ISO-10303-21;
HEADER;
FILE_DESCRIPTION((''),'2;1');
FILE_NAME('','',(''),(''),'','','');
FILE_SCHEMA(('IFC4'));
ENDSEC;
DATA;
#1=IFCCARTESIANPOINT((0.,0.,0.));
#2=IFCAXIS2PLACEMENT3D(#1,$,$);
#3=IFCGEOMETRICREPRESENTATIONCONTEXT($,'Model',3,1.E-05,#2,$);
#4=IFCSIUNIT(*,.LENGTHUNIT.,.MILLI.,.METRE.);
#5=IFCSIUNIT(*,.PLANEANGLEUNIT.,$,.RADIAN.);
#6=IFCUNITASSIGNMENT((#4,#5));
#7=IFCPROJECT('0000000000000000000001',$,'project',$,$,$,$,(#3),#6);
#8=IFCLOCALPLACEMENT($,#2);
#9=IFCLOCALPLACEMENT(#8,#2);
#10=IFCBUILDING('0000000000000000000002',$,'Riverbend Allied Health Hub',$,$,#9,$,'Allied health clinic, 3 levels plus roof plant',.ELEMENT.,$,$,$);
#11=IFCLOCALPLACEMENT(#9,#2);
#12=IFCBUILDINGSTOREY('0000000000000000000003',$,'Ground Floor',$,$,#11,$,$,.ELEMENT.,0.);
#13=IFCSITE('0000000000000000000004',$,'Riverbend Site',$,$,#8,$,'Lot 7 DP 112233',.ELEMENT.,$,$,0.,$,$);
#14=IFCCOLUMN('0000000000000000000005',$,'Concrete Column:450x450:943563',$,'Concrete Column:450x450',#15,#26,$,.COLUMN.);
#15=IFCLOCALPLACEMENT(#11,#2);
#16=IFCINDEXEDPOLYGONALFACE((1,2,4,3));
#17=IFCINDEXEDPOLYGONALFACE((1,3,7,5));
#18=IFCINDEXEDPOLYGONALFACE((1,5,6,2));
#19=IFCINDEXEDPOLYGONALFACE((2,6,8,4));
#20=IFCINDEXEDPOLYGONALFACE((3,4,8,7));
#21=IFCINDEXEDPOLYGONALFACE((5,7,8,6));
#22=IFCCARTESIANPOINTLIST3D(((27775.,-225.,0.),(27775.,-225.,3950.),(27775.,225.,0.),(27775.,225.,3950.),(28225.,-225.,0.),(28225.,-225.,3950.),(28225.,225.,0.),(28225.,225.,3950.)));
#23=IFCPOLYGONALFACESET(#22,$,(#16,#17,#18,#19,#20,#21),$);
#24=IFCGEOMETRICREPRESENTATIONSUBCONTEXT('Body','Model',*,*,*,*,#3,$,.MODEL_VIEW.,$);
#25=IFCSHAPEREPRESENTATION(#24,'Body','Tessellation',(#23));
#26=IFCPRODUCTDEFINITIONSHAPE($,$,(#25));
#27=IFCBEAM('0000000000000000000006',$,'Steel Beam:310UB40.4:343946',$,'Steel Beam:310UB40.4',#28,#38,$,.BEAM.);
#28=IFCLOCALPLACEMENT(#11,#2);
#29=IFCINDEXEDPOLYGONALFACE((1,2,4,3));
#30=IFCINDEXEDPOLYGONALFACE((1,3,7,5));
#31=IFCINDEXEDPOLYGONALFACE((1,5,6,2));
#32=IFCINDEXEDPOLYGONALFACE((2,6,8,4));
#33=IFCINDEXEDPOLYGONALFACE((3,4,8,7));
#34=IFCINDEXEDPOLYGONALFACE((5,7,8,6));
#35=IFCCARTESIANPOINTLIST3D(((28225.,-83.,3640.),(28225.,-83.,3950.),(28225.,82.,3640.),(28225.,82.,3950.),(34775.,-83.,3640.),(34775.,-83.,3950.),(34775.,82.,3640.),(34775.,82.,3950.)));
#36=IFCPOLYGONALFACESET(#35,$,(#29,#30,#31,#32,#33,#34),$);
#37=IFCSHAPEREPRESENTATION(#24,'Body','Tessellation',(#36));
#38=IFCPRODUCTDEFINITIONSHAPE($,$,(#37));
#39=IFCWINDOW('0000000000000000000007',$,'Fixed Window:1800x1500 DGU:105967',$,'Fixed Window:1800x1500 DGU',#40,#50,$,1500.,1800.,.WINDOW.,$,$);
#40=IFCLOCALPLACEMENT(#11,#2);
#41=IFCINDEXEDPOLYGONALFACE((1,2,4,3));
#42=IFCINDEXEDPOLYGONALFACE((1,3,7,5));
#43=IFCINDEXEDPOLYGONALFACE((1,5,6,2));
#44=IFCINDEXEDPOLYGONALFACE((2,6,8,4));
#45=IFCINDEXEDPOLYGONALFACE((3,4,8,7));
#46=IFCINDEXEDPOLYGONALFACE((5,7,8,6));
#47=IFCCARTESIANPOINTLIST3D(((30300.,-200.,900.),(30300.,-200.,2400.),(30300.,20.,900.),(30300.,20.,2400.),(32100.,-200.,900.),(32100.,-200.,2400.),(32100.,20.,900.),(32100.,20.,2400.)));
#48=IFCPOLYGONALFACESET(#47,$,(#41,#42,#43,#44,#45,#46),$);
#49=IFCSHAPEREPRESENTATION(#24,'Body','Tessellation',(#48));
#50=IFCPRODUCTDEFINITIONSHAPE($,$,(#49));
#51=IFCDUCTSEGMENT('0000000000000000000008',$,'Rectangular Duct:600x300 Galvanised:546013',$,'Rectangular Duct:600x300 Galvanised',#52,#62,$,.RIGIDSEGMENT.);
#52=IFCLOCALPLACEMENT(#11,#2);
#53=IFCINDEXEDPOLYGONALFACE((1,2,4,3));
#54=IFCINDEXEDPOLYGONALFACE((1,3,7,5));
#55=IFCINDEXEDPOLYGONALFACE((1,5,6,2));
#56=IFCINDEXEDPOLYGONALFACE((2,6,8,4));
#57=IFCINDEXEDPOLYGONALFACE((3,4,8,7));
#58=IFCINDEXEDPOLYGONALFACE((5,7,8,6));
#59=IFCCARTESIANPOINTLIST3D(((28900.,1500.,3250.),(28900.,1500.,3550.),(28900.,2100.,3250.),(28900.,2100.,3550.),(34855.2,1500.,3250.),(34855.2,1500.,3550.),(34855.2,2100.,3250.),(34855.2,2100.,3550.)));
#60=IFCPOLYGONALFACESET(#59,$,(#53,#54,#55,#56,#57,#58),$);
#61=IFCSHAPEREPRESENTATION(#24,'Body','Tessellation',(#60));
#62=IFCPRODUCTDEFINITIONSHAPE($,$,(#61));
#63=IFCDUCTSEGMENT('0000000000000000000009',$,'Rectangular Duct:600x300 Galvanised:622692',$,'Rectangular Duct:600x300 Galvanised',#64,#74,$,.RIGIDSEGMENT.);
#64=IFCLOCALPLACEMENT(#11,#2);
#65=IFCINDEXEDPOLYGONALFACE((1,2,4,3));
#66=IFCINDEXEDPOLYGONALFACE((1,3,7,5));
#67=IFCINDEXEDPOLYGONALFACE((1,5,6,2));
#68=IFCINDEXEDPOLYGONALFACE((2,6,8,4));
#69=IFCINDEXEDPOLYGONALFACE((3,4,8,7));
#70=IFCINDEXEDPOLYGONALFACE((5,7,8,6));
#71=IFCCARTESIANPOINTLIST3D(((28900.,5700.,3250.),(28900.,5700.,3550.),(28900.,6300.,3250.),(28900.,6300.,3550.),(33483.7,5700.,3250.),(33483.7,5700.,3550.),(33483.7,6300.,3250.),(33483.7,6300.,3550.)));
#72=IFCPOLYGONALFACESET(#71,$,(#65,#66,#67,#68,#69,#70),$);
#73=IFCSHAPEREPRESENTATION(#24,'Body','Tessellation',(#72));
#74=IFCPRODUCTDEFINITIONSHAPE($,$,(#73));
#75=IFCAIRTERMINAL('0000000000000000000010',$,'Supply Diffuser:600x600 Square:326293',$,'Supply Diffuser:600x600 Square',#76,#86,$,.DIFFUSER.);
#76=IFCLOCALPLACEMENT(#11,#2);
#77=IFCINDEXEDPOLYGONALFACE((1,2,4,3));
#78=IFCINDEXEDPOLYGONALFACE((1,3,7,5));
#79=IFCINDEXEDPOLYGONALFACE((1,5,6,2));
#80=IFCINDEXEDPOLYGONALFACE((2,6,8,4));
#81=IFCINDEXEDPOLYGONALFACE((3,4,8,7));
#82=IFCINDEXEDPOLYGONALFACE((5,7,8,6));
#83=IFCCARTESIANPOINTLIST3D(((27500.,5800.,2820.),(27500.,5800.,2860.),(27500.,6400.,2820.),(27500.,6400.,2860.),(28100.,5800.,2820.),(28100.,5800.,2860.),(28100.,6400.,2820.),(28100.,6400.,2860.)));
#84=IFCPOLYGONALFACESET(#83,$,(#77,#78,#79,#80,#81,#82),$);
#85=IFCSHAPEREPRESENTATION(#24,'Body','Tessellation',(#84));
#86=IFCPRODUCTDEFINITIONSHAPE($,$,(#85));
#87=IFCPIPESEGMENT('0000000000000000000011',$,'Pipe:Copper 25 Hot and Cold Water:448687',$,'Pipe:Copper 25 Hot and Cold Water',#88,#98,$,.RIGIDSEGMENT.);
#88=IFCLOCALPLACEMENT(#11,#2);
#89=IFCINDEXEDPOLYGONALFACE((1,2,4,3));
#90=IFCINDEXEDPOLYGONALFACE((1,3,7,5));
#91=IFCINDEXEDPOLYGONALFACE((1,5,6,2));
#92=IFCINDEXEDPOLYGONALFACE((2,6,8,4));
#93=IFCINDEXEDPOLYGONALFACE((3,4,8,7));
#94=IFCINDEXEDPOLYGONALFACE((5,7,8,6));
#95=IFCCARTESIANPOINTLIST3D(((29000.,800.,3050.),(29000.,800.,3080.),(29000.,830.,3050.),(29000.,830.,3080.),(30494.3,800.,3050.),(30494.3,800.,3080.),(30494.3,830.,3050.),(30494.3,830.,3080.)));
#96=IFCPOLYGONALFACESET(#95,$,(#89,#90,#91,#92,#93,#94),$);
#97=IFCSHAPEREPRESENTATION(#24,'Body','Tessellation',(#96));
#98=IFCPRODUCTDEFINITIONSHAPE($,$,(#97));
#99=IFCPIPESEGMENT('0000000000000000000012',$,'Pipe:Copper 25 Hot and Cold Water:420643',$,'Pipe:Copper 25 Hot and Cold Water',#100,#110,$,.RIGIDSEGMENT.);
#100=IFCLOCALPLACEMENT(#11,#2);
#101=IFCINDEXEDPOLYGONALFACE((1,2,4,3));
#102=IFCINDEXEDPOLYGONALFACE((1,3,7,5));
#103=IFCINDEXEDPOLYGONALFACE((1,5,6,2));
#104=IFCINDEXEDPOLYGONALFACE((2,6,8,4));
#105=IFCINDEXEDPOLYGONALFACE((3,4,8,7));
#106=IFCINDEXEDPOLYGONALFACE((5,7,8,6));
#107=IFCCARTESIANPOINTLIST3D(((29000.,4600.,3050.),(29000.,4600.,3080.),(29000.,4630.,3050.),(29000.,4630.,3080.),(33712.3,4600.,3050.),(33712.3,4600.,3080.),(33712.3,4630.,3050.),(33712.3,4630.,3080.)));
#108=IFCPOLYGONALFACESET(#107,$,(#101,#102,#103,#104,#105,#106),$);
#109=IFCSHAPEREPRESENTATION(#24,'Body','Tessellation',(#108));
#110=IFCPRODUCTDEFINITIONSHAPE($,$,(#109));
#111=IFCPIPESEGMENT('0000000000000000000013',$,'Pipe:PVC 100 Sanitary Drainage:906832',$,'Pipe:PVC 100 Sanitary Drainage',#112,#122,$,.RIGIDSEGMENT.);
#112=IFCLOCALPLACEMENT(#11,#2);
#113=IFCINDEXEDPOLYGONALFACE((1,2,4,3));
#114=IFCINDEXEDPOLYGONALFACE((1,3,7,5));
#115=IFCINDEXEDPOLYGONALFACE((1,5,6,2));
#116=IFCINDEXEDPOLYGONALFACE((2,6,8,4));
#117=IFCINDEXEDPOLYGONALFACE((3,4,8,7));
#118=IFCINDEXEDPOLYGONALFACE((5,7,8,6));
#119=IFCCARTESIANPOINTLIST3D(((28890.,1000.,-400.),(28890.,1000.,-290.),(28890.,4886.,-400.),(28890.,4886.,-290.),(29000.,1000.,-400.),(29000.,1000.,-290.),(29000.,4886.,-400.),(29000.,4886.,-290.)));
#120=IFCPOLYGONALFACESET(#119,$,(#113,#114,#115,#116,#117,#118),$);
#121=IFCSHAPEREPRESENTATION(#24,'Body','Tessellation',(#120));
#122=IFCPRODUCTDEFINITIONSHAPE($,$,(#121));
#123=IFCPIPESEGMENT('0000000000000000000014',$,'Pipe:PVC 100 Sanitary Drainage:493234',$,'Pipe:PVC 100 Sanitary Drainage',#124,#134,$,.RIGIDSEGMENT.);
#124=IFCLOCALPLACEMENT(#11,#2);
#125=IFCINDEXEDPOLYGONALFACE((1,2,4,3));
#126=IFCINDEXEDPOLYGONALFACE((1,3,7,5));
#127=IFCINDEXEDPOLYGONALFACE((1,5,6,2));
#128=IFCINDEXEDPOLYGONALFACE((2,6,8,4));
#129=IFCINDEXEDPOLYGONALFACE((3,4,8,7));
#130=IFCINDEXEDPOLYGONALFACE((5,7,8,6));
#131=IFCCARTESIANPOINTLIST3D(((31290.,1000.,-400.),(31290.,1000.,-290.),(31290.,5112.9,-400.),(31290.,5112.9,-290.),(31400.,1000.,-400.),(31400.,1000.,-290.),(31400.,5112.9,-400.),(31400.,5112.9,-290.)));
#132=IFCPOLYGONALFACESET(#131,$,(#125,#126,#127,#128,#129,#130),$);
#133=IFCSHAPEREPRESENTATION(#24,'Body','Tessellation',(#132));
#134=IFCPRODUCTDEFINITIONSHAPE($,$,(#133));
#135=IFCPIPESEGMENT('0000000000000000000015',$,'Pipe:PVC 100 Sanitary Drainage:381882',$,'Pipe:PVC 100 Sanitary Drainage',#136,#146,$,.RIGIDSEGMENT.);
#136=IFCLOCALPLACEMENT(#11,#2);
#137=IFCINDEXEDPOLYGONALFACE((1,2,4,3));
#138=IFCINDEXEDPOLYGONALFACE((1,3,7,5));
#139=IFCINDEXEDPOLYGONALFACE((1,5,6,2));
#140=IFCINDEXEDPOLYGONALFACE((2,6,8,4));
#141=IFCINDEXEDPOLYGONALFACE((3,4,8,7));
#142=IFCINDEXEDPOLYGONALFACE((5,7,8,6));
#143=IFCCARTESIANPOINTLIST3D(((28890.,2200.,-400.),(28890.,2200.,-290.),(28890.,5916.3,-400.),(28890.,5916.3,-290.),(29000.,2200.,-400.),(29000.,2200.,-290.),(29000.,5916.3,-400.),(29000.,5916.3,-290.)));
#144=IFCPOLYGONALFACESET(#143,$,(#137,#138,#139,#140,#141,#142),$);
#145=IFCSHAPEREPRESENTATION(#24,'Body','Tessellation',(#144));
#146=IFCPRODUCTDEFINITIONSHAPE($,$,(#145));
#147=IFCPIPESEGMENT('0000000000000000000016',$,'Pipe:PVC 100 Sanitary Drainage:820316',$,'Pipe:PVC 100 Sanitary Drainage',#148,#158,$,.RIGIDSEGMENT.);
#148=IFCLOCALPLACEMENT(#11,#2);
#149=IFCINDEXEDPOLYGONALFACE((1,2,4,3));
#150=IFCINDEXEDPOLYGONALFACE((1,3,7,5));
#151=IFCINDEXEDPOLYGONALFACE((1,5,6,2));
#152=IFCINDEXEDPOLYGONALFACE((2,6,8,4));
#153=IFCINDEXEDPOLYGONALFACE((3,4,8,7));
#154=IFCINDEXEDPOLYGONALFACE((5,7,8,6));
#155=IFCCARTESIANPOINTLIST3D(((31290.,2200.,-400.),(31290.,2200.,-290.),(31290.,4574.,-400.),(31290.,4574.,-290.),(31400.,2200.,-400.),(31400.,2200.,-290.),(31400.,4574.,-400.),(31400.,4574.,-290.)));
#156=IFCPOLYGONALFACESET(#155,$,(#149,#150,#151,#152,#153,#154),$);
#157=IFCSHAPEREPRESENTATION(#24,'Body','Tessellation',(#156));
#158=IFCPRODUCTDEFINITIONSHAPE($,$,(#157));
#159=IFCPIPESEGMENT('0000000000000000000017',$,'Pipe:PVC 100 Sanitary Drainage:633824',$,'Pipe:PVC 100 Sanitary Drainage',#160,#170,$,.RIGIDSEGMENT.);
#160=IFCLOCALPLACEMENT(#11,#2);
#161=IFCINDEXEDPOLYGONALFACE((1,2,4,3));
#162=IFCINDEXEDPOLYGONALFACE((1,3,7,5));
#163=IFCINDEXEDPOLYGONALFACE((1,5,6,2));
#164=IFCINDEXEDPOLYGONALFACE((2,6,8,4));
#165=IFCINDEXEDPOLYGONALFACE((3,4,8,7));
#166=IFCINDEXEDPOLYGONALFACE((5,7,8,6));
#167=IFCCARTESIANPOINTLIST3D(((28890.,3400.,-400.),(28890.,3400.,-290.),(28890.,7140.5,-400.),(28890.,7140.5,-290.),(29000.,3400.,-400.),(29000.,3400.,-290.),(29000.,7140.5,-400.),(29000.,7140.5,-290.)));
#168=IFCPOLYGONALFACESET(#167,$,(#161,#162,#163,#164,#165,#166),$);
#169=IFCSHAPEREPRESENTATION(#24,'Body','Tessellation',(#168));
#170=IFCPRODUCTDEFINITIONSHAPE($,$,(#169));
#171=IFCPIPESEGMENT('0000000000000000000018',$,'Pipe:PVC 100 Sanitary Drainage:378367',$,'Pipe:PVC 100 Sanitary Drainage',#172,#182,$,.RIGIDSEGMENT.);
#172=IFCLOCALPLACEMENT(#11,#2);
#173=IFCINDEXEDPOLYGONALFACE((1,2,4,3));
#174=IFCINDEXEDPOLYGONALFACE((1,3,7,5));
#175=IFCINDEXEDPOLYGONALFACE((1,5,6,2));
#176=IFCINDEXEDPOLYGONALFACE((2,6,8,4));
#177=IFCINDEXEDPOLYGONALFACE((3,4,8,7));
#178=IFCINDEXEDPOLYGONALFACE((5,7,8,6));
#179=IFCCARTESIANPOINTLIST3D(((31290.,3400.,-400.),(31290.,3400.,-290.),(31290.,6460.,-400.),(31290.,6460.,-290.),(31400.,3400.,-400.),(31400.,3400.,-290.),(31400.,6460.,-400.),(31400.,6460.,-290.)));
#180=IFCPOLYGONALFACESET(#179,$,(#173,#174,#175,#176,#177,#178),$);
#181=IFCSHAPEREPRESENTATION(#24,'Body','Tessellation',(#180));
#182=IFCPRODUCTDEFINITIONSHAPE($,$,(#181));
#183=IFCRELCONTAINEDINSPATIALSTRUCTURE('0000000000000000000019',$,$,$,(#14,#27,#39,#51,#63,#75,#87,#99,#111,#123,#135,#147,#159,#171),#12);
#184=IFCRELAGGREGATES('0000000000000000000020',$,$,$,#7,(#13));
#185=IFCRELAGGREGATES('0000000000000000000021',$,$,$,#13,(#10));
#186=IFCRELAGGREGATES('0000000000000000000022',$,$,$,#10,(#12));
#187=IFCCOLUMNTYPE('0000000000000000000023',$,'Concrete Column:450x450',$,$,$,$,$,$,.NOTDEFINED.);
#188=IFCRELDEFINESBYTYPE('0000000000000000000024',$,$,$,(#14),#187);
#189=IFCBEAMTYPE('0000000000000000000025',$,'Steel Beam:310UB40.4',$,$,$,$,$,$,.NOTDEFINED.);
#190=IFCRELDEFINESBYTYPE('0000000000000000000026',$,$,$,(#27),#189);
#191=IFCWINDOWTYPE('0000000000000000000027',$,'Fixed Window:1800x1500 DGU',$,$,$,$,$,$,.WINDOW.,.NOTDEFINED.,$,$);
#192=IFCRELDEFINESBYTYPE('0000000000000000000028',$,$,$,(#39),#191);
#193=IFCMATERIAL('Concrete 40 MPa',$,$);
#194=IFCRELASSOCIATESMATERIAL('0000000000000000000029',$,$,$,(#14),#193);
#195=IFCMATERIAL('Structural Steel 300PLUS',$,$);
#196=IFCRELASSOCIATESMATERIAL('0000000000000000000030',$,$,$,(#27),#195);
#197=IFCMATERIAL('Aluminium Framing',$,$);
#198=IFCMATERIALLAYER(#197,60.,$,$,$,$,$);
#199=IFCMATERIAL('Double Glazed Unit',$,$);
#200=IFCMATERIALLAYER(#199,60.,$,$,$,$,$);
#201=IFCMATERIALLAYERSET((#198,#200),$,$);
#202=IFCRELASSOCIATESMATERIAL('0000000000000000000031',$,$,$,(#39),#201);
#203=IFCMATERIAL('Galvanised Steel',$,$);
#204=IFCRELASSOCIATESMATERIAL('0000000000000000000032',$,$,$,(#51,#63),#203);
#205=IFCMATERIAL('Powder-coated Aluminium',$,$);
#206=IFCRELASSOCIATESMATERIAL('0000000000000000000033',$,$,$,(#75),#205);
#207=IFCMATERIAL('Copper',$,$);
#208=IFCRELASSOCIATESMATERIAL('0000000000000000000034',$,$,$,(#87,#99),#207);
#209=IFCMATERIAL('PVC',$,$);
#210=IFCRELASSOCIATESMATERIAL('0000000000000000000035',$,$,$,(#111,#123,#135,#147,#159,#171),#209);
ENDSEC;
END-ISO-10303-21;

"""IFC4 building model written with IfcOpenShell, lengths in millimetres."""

from ifc_helpers import new_model, si_unit, frame, frame_2d, origin, place, context, subcontext, project, spatial, rectangle, extrude, material, layer, layer_set, layer_usage, type_object, element, save


model = new_model("IFC4")

# Units and contexts
model_context = context("Model", 3, precision=1e-05, world=origin())
body_context = subcontext(model_context, "Body", "Model", "MODEL_VIEW")
ifc_project = project(units=[si_unit("LENGTHUNIT", "METRE", prefix="MILLI"), si_unit("PLANEANGLEUNIT", "RADIAN")], contexts=[model_context])

# Site, building, storey
site_placement = place(None, origin())
site = spatial("IfcSite", under=ifc_project, at=site_placement, Name="Riverbend Site", LongName="Lot 7 DP 112233", CompositionType="ELEMENT", RefElevation=0.0)
building_placement = place(site_placement, origin())
building = spatial("IfcBuilding", under=site, at=building_placement, Name="Riverbend Allied Health Hub", LongName="Allied health clinic, 3 levels plus roof plant", CompositionType="ELEMENT")
storey_placement = place(building_placement, origin())
storey = spatial("IfcBuildingStorey", under=building, at=storey_placement, Name="Ground Floor", CompositionType="ELEMENT", Elevation=0.0)

# Column
ifc_material_1 = material(Name="Concrete 40 MPa")
column_type = type_object("IfcColumnType", Name="Concrete Column:450x450", PredefinedType="NOTDEFINED")
column_placement = place(storey_placement, frame((27775.0, -225.0, 0.0)))
element("IfcColumn", 1, at=column_placement, inside=storey, type_object=column_type, material=ifc_material_1, Name="Concrete Column:450x450:943563", ObjectType="Concrete Column:450x450", PredefinedType="COLUMN", context=body_context, shape_type="SweptSolid", body=[
    extrude(rectangle(XDim=450.0, YDim=450.0, at=frame_2d((225.0, 225.0))), origin(), (0.0, 0.0, 1.0), 3950.0),
])

# Beam
ifc_material_2 = material(Name="Structural Steel 300PLUS")
beam_type = type_object("IfcBeamType", Name="Steel Beam:310UB40.4", PredefinedType="NOTDEFINED")
beam_placement = place(storey_placement, frame((28225.0, -83.0, 3640.0)))
element("IfcBeam", 2, at=beam_placement, inside=storey, type_object=beam_type, material=ifc_material_2, Name="Steel Beam:310UB40.4:343946", ObjectType="Steel Beam:310UB40.4", PredefinedType="BEAM", context=body_context, shape_type="SweptSolid", body=[
    extrude(rectangle(XDim=6550.0, YDim=165.0, at=frame_2d((3275.0, 82.5))), origin(), (0.0, 0.0, 1.0), 310.0),
])

# Window
ifc_material_3 = material(Name="Aluminium Framing")
ifc_layer_1 = layer(ifc_material_3, 60.0)
ifc_material_4 = material(Name="Double Glazed Unit")
ifc_layer_2 = layer(ifc_material_4, 60.0)
ifc_layer_set = layer_set([ifc_layer_1, ifc_layer_2])
ifc_layer_usage = layer_usage(ifc_layer_set, "AXIS2", "POSITIVE", 0.0)
window_type = type_object("IfcWindowType", Name="Fixed Window:1800x1500 DGU", PartitioningType="NOTDEFINED", PredefinedType="WINDOW")
window_placement = place(storey_placement, frame((30300.0, -200.0, 900.0)))
element("IfcWindow", 3, at=window_placement, inside=storey, type_object=window_type, material=ifc_layer_usage, Name="Fixed Window:1800x1500 DGU:105967", ObjectType="Fixed Window:1800x1500 DGU", OverallHeight=1500.0, OverallWidth=1800.0, PredefinedType="WINDOW", context=body_context, shape_type="SweptSolid", body=[
    extrude(rectangle(XDim=1800.0, YDim=220.0, at=frame_2d((900.0, 110.0))), origin(), (0.0, 0.0, 1.0), 1500.0),
])

# Duct segments
ifc_material_5 = material(Name="Galvanised Steel")
duct_segment_1_placement = place(storey_placement, frame((28900.0, 1500.0, 3250.0)))
element("IfcDuctSegment", 4, at=duct_segment_1_placement, inside=storey, material=ifc_material_5, Name="Rectangular Duct:600x300 Galvanised:546013", ObjectType="Rectangular Duct:600x300 Galvanised", PredefinedType="RIGIDSEGMENT", context=body_context, shape_type="SweptSolid", body=[
    extrude(rectangle(XDim=5955.2, YDim=600.0, at=frame_2d((2977.6, 300.0))), origin(), (0.0, 0.0, 1.0), 300.0),
])
duct_segment_2_placement = place(storey_placement, frame((28900.0, 5700.0, 3250.0)))
element("IfcDuctSegment", 5, at=duct_segment_2_placement, inside=storey, material=ifc_material_5, Name="Rectangular Duct:600x300 Galvanised:622692", ObjectType="Rectangular Duct:600x300 Galvanised", PredefinedType="RIGIDSEGMENT", context=body_context, shape_type="SweptSolid", body=[
    extrude(rectangle(XDim=4583.7, YDim=600.0, at=frame_2d((2291.8, 300.0))), origin(), (0.0, 0.0, 1.0), 300.0),
])

# Air terminal
ifc_material_6 = material(Name="Powder-coated Aluminium")
air_terminal_placement = place(storey_placement, frame((27500.0, 5800.0, 2820.0)))
element("IfcAirTerminal", 6, at=air_terminal_placement, inside=storey, material=ifc_material_6, Name="Supply Diffuser:600x600 Square:326293", ObjectType="Supply Diffuser:600x600 Square", PredefinedType="DIFFUSER", context=body_context, shape_type="SweptSolid", body=[
    extrude(rectangle(XDim=600.0, YDim=600.0, at=frame_2d((300.0, 300.0))), origin(), (0.0, 0.0, 1.0), 40.0),
])

# Pipe segments
ifc_material_7 = material(Name="Copper")
pipe_segment_1_placement = place(storey_placement, frame((29000.0, 800.0, 3050.0)))
element("IfcPipeSegment", 7, at=pipe_segment_1_placement, inside=storey, material=ifc_material_7, Name="Pipe:Copper 25 Hot and Cold Water:448687", ObjectType="Pipe:Copper 25 Hot and Cold Water", PredefinedType="RIGIDSEGMENT", context=body_context, shape_type="SweptSolid", body=[
    extrude(rectangle(XDim=1494.3, YDim=30.0, at=frame_2d((747.1, 15.0))), origin(), (0.0, 0.0, 1.0), 30.0),
])
pipe_segment_2_placement = place(storey_placement, frame((29000.0, 4600.0, 3050.0)))
element("IfcPipeSegment", 8, at=pipe_segment_2_placement, inside=storey, material=ifc_material_7, Name="Pipe:Copper 25 Hot and Cold Water:420643", ObjectType="Pipe:Copper 25 Hot and Cold Water", PredefinedType="RIGIDSEGMENT", context=body_context, shape_type="SweptSolid", body=[
    extrude(rectangle(XDim=4712.3, YDim=30.0, at=frame_2d((2356.1, 15.0))), origin(), (0.0, 0.0, 1.0), 30.0),
])
ifc_material_8 = material(Name="PVC")
pipe_segment_3_placement = place(storey_placement, frame((29000.0, 1000.0, -400.0), z_axis=(0.0, 0.0, 1.0), x_axis=(0.0, 1.0, 0.0)))
element("IfcPipeSegment", 9, at=pipe_segment_3_placement, inside=storey, material=ifc_material_8, Name="Pipe:PVC 100 Sanitary Drainage:906832", ObjectType="Pipe:PVC 100 Sanitary Drainage", PredefinedType="RIGIDSEGMENT", context=body_context, shape_type="SweptSolid", body=[
    extrude(rectangle(XDim=3886.0, YDim=110.0, at=frame_2d((1943.0, 55.0))), origin(), (0.0, 0.0, 1.0), 110.0),
])
pipe_segment_4_placement = place(storey_placement, frame((31400.0, 1000.0, -400.0), z_axis=(0.0, 0.0, 1.0), x_axis=(0.0, 1.0, 0.0)))
element("IfcPipeSegment", 10, at=pipe_segment_4_placement, inside=storey, material=ifc_material_8, Name="Pipe:PVC 100 Sanitary Drainage:493234", ObjectType="Pipe:PVC 100 Sanitary Drainage", PredefinedType="RIGIDSEGMENT", context=body_context, shape_type="SweptSolid", body=[
    extrude(rectangle(XDim=4112.9, YDim=110.0, at=frame_2d((2056.5, 55.0))), origin(), (0.0, 0.0, 1.0), 110.0),
])
pipe_segment_5_placement = place(storey_placement, frame((29000.0, 2200.0, -400.0), z_axis=(0.0, 0.0, 1.0), x_axis=(0.0, 1.0, 0.0)))
element("IfcPipeSegment", 11, at=pipe_segment_5_placement, inside=storey, material=ifc_material_8, Name="Pipe:PVC 100 Sanitary Drainage:381882", ObjectType="Pipe:PVC 100 Sanitary Drainage", PredefinedType="RIGIDSEGMENT", context=body_context, shape_type="SweptSolid", body=[
    extrude(rectangle(XDim=3716.3, YDim=110.0, at=frame_2d((1858.2, 55.0))), origin(), (0.0, 0.0, 1.0), 110.0),
])
pipe_segment_6_placement = place(storey_placement, frame((31400.0, 2200.0, -400.0), z_axis=(0.0, 0.0, 1.0), x_axis=(0.0, 1.0, 0.0)))
element("IfcPipeSegment", 12, at=pipe_segment_6_placement, inside=storey, material=ifc_material_8, Name="Pipe:PVC 100 Sanitary Drainage:820316", ObjectType="Pipe:PVC 100 Sanitary Drainage", PredefinedType="RIGIDSEGMENT", context=body_context, shape_type="SweptSolid", body=[
    extrude(rectangle(XDim=2374.0, YDim=110.0, at=frame_2d((1187.0, 55.0))), origin(), (0.0, 0.0, 1.0), 110.0),
])
pipe_segment_7_placement = place(storey_placement, frame((29000.0, 3400.0, -400.0), z_axis=(0.0, 0.0, 1.0), x_axis=(0.0, 1.0, 0.0)))
element("IfcPipeSegment", 13, at=pipe_segment_7_placement, inside=storey, material=ifc_material_8, Name="Pipe:PVC 100 Sanitary Drainage:633824", ObjectType="Pipe:PVC 100 Sanitary Drainage", PredefinedType="RIGIDSEGMENT", context=body_context, shape_type="SweptSolid", body=[
    extrude(rectangle(XDim=3740.5, YDim=110.0, at=frame_2d((1870.2, 55.0))), origin(), (0.0, 0.0, 1.0), 110.0),
])
pipe_segment_8_placement = place(storey_placement, frame((31400.0, 3400.0, -400.0), z_axis=(0.0, 0.0, 1.0), x_axis=(0.0, 1.0, 0.0)))
element("IfcPipeSegment", 14, at=pipe_segment_8_placement, inside=storey, material=ifc_material_8, Name="Pipe:PVC 100 Sanitary Drainage:378367", ObjectType="Pipe:PVC 100 Sanitary Drainage", PredefinedType="RIGIDSEGMENT", context=body_context, shape_type="SweptSolid", body=[
    extrude(rectangle(XDim=3060.0, YDim=110.0, at=frame_2d((1530.0, 55.0))), origin(), (0.0, 0.0, 1.0), 110.0),
])

save(model, "model.ifc")
